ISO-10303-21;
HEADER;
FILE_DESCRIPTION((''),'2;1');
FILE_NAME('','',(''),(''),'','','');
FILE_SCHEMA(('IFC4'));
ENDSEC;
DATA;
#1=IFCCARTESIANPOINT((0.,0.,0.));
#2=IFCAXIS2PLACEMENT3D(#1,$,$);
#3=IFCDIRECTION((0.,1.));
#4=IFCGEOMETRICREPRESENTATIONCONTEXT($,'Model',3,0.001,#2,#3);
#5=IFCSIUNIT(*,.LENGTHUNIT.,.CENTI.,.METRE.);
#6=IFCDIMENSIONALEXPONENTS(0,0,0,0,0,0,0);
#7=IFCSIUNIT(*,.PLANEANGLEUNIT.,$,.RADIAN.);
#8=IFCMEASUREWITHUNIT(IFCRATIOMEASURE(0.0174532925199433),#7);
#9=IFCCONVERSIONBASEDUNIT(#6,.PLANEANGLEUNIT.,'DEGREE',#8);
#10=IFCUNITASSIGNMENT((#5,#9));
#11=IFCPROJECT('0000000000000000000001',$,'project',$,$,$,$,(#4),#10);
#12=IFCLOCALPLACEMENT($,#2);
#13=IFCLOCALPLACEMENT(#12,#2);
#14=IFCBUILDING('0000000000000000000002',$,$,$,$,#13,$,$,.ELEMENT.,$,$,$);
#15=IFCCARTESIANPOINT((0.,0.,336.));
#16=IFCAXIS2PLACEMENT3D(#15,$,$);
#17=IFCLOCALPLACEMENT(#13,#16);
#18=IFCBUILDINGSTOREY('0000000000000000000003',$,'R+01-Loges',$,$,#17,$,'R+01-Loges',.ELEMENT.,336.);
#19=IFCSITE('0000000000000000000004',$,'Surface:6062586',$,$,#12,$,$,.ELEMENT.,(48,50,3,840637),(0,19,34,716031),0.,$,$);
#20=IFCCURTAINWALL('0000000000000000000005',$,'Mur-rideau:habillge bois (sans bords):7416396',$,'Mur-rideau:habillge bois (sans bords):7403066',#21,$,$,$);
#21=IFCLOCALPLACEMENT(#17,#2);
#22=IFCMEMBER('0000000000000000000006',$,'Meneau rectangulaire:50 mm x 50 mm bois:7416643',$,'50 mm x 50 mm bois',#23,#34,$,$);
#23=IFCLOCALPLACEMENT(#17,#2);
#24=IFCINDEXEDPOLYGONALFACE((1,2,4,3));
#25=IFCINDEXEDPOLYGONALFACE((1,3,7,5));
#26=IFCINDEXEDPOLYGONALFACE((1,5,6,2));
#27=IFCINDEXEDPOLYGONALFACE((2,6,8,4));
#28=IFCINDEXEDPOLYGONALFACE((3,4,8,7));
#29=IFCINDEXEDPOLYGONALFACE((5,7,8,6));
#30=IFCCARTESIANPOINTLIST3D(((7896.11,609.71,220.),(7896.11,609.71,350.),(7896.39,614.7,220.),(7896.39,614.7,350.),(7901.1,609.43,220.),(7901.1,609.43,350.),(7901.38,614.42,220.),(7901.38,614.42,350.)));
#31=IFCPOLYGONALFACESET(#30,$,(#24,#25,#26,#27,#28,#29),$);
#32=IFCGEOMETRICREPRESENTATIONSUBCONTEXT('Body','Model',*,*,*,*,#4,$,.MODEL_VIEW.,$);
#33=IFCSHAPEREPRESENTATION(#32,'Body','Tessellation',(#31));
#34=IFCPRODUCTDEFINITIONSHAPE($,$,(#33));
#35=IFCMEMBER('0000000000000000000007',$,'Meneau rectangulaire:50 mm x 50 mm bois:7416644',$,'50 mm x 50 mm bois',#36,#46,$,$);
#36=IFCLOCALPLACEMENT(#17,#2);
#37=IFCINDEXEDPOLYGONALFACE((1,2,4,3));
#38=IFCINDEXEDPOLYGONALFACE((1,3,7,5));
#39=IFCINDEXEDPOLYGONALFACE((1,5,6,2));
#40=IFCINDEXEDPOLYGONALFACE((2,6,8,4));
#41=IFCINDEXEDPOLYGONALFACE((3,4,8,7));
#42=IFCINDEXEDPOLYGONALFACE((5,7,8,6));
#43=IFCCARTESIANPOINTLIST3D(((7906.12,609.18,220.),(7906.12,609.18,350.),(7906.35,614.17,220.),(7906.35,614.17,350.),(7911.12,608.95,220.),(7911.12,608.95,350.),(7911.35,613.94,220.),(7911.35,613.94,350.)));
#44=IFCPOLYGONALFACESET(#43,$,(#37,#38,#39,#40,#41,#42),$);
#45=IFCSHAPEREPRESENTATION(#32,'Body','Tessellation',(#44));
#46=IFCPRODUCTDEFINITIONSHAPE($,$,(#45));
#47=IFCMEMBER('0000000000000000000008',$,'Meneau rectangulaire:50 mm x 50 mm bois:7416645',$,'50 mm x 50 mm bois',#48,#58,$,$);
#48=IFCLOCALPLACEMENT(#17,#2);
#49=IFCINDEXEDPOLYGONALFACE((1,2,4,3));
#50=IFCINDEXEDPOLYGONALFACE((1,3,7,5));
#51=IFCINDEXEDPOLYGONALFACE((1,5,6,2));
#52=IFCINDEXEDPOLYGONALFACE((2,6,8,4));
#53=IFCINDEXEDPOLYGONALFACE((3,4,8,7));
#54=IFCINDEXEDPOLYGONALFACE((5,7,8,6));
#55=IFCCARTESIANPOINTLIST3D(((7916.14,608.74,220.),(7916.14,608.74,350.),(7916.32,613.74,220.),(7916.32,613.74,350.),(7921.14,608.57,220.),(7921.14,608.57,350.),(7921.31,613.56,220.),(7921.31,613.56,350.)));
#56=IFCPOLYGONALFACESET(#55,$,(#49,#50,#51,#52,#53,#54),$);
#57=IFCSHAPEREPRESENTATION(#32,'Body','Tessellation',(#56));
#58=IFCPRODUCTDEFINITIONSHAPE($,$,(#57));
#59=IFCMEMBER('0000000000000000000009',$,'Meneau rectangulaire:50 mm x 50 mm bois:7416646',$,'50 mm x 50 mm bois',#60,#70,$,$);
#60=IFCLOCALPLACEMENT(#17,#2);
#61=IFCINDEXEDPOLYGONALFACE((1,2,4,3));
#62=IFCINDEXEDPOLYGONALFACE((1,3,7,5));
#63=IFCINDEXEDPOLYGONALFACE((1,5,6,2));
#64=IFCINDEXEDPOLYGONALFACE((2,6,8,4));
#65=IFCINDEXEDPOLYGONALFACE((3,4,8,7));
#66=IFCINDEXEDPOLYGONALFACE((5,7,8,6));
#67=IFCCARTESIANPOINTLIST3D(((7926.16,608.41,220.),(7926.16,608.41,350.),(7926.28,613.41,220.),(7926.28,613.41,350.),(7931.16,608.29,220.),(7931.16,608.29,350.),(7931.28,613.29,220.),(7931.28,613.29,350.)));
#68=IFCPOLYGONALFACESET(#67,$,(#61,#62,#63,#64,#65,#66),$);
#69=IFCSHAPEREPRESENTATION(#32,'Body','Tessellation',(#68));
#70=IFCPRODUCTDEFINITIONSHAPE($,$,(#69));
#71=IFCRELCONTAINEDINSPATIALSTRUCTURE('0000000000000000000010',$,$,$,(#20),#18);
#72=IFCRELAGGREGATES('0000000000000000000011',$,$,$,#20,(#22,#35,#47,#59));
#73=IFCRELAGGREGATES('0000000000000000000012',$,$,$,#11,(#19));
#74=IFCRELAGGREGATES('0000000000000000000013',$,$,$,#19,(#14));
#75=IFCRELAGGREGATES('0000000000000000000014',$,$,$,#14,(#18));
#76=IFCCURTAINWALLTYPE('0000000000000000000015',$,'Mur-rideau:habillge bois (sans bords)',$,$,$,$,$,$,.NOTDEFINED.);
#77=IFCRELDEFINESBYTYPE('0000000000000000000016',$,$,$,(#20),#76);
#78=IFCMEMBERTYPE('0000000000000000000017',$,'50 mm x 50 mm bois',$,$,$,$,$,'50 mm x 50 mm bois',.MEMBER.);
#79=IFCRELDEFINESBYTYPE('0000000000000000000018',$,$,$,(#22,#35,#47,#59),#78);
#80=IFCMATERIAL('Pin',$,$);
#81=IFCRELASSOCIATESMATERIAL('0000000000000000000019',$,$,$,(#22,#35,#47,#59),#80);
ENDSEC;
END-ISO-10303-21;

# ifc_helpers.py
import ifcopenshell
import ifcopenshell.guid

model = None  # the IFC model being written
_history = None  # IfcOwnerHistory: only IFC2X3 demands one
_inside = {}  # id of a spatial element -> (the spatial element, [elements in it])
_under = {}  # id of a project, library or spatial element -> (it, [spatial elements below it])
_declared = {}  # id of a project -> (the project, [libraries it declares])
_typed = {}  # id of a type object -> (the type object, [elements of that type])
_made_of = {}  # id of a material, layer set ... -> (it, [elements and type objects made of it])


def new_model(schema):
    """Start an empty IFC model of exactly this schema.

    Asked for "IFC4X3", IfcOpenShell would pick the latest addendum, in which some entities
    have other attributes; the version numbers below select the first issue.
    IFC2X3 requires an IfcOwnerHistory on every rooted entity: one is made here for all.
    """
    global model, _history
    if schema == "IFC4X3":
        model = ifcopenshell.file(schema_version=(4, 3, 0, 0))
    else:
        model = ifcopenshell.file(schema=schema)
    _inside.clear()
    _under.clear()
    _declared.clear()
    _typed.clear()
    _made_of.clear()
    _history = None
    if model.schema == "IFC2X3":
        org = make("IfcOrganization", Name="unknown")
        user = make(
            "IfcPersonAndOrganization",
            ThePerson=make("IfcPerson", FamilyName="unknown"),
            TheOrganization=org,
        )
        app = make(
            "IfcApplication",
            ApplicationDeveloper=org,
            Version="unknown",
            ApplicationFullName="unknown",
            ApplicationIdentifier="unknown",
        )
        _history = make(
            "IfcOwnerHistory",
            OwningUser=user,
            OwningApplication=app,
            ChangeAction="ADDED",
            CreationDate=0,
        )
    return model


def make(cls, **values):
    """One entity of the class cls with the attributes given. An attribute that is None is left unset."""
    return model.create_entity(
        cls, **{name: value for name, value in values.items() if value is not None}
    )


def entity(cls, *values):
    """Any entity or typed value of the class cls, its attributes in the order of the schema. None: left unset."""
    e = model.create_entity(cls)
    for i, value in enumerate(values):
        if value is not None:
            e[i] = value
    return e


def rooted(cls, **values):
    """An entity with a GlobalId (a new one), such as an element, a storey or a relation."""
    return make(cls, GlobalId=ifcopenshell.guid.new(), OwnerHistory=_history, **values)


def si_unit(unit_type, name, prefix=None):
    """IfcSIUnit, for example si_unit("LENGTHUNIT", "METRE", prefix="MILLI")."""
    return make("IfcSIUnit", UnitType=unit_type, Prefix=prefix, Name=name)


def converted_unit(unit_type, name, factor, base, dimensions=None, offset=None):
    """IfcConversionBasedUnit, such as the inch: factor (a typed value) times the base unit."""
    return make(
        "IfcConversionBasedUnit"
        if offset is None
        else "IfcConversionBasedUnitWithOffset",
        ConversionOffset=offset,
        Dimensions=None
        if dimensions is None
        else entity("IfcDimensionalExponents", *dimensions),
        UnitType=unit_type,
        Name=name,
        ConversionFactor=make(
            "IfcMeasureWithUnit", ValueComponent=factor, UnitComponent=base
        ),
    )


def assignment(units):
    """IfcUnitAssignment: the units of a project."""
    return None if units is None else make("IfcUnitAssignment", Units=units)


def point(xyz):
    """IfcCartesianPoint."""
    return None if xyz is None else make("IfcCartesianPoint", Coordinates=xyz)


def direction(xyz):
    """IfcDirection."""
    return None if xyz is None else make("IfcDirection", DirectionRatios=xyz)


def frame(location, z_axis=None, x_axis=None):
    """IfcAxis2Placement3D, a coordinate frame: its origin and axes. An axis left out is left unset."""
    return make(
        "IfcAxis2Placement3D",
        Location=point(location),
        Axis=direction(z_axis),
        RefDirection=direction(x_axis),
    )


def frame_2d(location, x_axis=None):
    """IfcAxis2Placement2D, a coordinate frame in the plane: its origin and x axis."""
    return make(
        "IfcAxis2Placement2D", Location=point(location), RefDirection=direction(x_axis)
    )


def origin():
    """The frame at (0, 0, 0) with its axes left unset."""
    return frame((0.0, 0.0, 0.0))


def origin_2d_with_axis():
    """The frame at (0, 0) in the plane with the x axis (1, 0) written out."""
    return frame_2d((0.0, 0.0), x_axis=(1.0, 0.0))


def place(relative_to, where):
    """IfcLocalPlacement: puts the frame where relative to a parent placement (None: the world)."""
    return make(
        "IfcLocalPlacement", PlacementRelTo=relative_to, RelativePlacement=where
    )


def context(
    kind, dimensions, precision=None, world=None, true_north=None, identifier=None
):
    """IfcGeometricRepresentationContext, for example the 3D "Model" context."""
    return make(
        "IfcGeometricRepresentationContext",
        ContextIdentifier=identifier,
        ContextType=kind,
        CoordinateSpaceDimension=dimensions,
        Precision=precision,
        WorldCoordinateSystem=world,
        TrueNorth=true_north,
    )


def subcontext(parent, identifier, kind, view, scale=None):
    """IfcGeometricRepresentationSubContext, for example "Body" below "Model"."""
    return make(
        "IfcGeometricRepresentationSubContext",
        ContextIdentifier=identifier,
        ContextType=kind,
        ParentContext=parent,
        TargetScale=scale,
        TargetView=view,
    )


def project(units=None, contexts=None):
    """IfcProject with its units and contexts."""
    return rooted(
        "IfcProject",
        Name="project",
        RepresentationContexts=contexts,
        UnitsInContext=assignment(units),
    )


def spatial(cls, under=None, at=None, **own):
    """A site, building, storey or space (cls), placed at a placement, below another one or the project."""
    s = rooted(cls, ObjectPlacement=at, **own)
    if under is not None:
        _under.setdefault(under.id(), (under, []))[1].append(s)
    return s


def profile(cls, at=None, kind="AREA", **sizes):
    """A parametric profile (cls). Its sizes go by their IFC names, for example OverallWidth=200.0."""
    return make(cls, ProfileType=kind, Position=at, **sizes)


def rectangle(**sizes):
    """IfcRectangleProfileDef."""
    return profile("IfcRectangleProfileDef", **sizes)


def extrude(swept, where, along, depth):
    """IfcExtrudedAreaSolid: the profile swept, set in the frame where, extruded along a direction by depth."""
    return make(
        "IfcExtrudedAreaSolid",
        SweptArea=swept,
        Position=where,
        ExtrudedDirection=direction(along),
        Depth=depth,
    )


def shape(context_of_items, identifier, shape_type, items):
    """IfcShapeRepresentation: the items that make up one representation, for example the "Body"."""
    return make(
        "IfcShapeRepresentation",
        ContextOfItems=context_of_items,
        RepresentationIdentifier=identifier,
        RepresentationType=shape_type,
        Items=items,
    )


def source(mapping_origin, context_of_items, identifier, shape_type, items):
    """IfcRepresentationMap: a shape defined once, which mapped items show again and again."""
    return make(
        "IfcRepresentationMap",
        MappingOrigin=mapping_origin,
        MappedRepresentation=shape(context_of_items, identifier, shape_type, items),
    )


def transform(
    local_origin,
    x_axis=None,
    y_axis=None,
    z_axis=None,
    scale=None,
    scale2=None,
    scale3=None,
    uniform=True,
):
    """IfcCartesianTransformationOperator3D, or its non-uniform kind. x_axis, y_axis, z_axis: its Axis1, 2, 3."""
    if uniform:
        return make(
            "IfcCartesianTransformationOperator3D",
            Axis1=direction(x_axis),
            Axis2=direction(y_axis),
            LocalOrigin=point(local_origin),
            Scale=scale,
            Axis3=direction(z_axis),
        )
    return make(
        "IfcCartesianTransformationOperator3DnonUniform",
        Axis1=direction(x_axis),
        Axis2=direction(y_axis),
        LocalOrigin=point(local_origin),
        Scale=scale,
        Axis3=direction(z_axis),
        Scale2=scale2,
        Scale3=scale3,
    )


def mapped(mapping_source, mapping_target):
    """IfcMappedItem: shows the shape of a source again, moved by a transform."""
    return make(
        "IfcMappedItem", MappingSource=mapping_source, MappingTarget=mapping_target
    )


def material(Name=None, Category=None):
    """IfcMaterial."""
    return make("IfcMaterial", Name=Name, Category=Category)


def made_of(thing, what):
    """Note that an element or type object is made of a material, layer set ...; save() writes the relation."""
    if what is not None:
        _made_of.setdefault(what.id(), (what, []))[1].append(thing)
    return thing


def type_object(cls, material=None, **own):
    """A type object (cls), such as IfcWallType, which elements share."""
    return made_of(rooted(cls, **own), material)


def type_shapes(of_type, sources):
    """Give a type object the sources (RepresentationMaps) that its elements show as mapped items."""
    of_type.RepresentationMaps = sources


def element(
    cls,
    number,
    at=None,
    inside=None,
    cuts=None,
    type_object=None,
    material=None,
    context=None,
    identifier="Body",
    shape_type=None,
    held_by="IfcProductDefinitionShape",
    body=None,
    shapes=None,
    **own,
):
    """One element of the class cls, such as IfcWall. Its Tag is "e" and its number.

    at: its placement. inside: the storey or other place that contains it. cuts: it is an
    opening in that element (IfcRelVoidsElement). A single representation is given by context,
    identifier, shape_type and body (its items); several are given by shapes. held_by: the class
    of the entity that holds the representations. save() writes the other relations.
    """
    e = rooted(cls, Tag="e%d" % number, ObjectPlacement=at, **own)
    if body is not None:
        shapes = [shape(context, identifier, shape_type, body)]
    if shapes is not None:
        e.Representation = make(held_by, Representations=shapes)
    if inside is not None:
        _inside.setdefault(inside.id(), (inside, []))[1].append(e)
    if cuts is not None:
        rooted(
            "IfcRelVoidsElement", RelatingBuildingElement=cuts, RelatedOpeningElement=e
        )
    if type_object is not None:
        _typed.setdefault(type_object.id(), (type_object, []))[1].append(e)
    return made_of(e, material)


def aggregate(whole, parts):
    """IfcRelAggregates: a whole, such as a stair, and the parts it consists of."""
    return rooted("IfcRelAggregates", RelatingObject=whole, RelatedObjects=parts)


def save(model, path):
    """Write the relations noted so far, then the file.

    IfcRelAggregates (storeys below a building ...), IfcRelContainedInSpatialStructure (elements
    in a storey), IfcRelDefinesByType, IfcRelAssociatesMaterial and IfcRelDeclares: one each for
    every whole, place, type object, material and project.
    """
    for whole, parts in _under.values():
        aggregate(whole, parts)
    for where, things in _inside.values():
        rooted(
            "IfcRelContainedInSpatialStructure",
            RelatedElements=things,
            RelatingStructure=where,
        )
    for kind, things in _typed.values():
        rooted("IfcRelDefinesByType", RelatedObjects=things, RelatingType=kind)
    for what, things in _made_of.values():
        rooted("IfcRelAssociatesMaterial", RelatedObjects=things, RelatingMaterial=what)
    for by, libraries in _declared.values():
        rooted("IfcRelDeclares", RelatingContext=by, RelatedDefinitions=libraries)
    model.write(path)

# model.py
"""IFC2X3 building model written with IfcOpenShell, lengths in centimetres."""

from ifc_helpers import new_model, entity, si_unit, converted_unit, direction, frame, origin, origin_2d_with_axis, place, context, subcontext, project, spatial, rectangle, extrude, source, transform, mapped, material, type_object, type_shapes, element, aggregate, save


model = new_model("IFC2X3")

# Units and contexts
model_context = context("Model", 3, precision=0.001, world=origin(), true_north=direction((0.0, 1.0)))
body_context = subcontext(model_context, "Body", "Model", "MODEL_VIEW")
ifc_project = project(units=[si_unit("LENGTHUNIT", "METRE", prefix="CENTI"), converted_unit("PLANEANGLEUNIT", "DEGREE", entity("IfcRatioMeasure", 0.0174532925199433), si_unit("PLANEANGLEUNIT", "RADIAN"), dimensions=[0, 0, 0, 0, 0, 0, 0])], contexts=[model_context])

# Site, building, storey
site_placement = place(None, origin())
site = spatial("IfcSite", under=ifc_project, at=site_placement, Name="Surface:6062586", CompositionType="ELEMENT", RefLatitude=(48, 50, 3, 840637), RefLongitude=(0, 19, 34, 716031), RefElevation=0.0)
building_placement = place(site_placement, origin())
building = spatial("IfcBuilding", under=site, at=building_placement, CompositionType="ELEMENT")
storey_placement = place(building_placement, frame((0.0, 0.0, 336.0)))
storey = spatial("IfcBuildingStorey", under=building, at=storey_placement, Name="R+01-Loges", LongName="R+01-Loges", CompositionType="ELEMENT", Elevation=336.0)

# Curtain wall
curtain_wall_type = type_object("IfcCurtainWallType", Name="Mur-rideau:habillge bois (sans bords)", PredefinedType="NOTDEFINED")
ifc_material_1 = material(Name="Pin")
curtain_wall_1_placement = place(storey_placement, frame((0.0, 0.0, -336.0)))
curtain_wall_1 = element("IfcCurtainWall", 1, at=curtain_wall_1_placement, inside=storey, type_object=curtain_wall_type, Name="Mur-rideau:habillge bois (sans bords):7416396", ObjectType="Mur-rideau:habillge bois (sans bords):7403066")

# Members
member_type_1 = type_object("IfcMemberType", Name="50 mm x 50 mm bois", ElementType="50 mm x 50 mm bois", PredefinedType="MEMBER")
shared_shape_1 = source(origin(), body_context, "Body", "SweptSolid", [
    extrude(rectangle(XDim=5.0, YDim=5.0, at=origin_2d_with_axis()), frame((0.0, 0.0, -130.0), z_axis=(0.0, 0.0, 1.0), x_axis=(0.0, -1.0, 0.0)), (0.0, 0.0, 1.0), 130.0),
])
type_shapes(member_type_1, [shared_shape_1])
member_1_placement = place(storey_placement, frame((7898.75, 612.07, 220.0), z_axis=(0.0, 0.0, -1.0), x_axis=(0.998439, -0.055855, 0.0)))
member_1 = element("IfcMember", 2, at=member_1_placement, type_object=member_type_1, material=ifc_material_1, Name="Meneau rectangulaire:50 mm x 50 mm bois:7416643", ObjectType="50 mm x 50 mm bois", context=body_context, shape_type="MappedRepresentation", body=[
    mapped(shared_shape_1, transform((0.0, 0.0, 0.0), scale=1.0)),
])
member_2_placement = place(storey_placement, frame((7908.73, 611.56, 220.0), z_axis=(0.0, 0.0, -1.0), x_axis=(0.998958, -0.045638, 0.0)))
member_2 = element("IfcMember", 3, at=member_2_placement, type_object=member_type_1, material=ifc_material_1, Name="Meneau rectangulaire:50 mm x 50 mm bois:7416644", ObjectType="50 mm x 50 mm bois", context=body_context, shape_type="MappedRepresentation", body=[
    mapped(shared_shape_1, transform((0.0, 0.0, 0.0), scale=1.0)),
])
member_3_placement = place(storey_placement, frame((7918.73, 611.15, 220.0), z_axis=(0.0, 0.0, -1.0), x_axis=(0.999373, -0.035416, 0.0)))
member_3 = element("IfcMember", 4, at=member_3_placement, type_object=member_type_1, material=ifc_material_1, Name="Meneau rectangulaire:50 mm x 50 mm bois:7416645", ObjectType="50 mm x 50 mm bois", context=body_context, shape_type="MappedRepresentation", body=[
    mapped(shared_shape_1, transform((0.0, 0.0, 0.0), scale=1.0)),
])
member_4_placement = place(storey_placement, frame((7928.72, 610.85, 220.0), z_axis=(0.0, 0.0, -1.0), x_axis=(0.999683, -0.02519, 0.0)))
member_4 = element("IfcMember", 5, at=member_4_placement, type_object=member_type_1, material=ifc_material_1, Name="Meneau rectangulaire:50 mm x 50 mm bois:7416646", ObjectType="50 mm x 50 mm bois", context=body_context, shape_type="MappedRepresentation", body=[
    mapped(shared_shape_1, transform((0.0, 0.0, 0.0), scale=1.0)),
])
aggregate(curtain_wall_1, [member_1, member_2, member_3, member_4])

save(model, "model.ifc")
